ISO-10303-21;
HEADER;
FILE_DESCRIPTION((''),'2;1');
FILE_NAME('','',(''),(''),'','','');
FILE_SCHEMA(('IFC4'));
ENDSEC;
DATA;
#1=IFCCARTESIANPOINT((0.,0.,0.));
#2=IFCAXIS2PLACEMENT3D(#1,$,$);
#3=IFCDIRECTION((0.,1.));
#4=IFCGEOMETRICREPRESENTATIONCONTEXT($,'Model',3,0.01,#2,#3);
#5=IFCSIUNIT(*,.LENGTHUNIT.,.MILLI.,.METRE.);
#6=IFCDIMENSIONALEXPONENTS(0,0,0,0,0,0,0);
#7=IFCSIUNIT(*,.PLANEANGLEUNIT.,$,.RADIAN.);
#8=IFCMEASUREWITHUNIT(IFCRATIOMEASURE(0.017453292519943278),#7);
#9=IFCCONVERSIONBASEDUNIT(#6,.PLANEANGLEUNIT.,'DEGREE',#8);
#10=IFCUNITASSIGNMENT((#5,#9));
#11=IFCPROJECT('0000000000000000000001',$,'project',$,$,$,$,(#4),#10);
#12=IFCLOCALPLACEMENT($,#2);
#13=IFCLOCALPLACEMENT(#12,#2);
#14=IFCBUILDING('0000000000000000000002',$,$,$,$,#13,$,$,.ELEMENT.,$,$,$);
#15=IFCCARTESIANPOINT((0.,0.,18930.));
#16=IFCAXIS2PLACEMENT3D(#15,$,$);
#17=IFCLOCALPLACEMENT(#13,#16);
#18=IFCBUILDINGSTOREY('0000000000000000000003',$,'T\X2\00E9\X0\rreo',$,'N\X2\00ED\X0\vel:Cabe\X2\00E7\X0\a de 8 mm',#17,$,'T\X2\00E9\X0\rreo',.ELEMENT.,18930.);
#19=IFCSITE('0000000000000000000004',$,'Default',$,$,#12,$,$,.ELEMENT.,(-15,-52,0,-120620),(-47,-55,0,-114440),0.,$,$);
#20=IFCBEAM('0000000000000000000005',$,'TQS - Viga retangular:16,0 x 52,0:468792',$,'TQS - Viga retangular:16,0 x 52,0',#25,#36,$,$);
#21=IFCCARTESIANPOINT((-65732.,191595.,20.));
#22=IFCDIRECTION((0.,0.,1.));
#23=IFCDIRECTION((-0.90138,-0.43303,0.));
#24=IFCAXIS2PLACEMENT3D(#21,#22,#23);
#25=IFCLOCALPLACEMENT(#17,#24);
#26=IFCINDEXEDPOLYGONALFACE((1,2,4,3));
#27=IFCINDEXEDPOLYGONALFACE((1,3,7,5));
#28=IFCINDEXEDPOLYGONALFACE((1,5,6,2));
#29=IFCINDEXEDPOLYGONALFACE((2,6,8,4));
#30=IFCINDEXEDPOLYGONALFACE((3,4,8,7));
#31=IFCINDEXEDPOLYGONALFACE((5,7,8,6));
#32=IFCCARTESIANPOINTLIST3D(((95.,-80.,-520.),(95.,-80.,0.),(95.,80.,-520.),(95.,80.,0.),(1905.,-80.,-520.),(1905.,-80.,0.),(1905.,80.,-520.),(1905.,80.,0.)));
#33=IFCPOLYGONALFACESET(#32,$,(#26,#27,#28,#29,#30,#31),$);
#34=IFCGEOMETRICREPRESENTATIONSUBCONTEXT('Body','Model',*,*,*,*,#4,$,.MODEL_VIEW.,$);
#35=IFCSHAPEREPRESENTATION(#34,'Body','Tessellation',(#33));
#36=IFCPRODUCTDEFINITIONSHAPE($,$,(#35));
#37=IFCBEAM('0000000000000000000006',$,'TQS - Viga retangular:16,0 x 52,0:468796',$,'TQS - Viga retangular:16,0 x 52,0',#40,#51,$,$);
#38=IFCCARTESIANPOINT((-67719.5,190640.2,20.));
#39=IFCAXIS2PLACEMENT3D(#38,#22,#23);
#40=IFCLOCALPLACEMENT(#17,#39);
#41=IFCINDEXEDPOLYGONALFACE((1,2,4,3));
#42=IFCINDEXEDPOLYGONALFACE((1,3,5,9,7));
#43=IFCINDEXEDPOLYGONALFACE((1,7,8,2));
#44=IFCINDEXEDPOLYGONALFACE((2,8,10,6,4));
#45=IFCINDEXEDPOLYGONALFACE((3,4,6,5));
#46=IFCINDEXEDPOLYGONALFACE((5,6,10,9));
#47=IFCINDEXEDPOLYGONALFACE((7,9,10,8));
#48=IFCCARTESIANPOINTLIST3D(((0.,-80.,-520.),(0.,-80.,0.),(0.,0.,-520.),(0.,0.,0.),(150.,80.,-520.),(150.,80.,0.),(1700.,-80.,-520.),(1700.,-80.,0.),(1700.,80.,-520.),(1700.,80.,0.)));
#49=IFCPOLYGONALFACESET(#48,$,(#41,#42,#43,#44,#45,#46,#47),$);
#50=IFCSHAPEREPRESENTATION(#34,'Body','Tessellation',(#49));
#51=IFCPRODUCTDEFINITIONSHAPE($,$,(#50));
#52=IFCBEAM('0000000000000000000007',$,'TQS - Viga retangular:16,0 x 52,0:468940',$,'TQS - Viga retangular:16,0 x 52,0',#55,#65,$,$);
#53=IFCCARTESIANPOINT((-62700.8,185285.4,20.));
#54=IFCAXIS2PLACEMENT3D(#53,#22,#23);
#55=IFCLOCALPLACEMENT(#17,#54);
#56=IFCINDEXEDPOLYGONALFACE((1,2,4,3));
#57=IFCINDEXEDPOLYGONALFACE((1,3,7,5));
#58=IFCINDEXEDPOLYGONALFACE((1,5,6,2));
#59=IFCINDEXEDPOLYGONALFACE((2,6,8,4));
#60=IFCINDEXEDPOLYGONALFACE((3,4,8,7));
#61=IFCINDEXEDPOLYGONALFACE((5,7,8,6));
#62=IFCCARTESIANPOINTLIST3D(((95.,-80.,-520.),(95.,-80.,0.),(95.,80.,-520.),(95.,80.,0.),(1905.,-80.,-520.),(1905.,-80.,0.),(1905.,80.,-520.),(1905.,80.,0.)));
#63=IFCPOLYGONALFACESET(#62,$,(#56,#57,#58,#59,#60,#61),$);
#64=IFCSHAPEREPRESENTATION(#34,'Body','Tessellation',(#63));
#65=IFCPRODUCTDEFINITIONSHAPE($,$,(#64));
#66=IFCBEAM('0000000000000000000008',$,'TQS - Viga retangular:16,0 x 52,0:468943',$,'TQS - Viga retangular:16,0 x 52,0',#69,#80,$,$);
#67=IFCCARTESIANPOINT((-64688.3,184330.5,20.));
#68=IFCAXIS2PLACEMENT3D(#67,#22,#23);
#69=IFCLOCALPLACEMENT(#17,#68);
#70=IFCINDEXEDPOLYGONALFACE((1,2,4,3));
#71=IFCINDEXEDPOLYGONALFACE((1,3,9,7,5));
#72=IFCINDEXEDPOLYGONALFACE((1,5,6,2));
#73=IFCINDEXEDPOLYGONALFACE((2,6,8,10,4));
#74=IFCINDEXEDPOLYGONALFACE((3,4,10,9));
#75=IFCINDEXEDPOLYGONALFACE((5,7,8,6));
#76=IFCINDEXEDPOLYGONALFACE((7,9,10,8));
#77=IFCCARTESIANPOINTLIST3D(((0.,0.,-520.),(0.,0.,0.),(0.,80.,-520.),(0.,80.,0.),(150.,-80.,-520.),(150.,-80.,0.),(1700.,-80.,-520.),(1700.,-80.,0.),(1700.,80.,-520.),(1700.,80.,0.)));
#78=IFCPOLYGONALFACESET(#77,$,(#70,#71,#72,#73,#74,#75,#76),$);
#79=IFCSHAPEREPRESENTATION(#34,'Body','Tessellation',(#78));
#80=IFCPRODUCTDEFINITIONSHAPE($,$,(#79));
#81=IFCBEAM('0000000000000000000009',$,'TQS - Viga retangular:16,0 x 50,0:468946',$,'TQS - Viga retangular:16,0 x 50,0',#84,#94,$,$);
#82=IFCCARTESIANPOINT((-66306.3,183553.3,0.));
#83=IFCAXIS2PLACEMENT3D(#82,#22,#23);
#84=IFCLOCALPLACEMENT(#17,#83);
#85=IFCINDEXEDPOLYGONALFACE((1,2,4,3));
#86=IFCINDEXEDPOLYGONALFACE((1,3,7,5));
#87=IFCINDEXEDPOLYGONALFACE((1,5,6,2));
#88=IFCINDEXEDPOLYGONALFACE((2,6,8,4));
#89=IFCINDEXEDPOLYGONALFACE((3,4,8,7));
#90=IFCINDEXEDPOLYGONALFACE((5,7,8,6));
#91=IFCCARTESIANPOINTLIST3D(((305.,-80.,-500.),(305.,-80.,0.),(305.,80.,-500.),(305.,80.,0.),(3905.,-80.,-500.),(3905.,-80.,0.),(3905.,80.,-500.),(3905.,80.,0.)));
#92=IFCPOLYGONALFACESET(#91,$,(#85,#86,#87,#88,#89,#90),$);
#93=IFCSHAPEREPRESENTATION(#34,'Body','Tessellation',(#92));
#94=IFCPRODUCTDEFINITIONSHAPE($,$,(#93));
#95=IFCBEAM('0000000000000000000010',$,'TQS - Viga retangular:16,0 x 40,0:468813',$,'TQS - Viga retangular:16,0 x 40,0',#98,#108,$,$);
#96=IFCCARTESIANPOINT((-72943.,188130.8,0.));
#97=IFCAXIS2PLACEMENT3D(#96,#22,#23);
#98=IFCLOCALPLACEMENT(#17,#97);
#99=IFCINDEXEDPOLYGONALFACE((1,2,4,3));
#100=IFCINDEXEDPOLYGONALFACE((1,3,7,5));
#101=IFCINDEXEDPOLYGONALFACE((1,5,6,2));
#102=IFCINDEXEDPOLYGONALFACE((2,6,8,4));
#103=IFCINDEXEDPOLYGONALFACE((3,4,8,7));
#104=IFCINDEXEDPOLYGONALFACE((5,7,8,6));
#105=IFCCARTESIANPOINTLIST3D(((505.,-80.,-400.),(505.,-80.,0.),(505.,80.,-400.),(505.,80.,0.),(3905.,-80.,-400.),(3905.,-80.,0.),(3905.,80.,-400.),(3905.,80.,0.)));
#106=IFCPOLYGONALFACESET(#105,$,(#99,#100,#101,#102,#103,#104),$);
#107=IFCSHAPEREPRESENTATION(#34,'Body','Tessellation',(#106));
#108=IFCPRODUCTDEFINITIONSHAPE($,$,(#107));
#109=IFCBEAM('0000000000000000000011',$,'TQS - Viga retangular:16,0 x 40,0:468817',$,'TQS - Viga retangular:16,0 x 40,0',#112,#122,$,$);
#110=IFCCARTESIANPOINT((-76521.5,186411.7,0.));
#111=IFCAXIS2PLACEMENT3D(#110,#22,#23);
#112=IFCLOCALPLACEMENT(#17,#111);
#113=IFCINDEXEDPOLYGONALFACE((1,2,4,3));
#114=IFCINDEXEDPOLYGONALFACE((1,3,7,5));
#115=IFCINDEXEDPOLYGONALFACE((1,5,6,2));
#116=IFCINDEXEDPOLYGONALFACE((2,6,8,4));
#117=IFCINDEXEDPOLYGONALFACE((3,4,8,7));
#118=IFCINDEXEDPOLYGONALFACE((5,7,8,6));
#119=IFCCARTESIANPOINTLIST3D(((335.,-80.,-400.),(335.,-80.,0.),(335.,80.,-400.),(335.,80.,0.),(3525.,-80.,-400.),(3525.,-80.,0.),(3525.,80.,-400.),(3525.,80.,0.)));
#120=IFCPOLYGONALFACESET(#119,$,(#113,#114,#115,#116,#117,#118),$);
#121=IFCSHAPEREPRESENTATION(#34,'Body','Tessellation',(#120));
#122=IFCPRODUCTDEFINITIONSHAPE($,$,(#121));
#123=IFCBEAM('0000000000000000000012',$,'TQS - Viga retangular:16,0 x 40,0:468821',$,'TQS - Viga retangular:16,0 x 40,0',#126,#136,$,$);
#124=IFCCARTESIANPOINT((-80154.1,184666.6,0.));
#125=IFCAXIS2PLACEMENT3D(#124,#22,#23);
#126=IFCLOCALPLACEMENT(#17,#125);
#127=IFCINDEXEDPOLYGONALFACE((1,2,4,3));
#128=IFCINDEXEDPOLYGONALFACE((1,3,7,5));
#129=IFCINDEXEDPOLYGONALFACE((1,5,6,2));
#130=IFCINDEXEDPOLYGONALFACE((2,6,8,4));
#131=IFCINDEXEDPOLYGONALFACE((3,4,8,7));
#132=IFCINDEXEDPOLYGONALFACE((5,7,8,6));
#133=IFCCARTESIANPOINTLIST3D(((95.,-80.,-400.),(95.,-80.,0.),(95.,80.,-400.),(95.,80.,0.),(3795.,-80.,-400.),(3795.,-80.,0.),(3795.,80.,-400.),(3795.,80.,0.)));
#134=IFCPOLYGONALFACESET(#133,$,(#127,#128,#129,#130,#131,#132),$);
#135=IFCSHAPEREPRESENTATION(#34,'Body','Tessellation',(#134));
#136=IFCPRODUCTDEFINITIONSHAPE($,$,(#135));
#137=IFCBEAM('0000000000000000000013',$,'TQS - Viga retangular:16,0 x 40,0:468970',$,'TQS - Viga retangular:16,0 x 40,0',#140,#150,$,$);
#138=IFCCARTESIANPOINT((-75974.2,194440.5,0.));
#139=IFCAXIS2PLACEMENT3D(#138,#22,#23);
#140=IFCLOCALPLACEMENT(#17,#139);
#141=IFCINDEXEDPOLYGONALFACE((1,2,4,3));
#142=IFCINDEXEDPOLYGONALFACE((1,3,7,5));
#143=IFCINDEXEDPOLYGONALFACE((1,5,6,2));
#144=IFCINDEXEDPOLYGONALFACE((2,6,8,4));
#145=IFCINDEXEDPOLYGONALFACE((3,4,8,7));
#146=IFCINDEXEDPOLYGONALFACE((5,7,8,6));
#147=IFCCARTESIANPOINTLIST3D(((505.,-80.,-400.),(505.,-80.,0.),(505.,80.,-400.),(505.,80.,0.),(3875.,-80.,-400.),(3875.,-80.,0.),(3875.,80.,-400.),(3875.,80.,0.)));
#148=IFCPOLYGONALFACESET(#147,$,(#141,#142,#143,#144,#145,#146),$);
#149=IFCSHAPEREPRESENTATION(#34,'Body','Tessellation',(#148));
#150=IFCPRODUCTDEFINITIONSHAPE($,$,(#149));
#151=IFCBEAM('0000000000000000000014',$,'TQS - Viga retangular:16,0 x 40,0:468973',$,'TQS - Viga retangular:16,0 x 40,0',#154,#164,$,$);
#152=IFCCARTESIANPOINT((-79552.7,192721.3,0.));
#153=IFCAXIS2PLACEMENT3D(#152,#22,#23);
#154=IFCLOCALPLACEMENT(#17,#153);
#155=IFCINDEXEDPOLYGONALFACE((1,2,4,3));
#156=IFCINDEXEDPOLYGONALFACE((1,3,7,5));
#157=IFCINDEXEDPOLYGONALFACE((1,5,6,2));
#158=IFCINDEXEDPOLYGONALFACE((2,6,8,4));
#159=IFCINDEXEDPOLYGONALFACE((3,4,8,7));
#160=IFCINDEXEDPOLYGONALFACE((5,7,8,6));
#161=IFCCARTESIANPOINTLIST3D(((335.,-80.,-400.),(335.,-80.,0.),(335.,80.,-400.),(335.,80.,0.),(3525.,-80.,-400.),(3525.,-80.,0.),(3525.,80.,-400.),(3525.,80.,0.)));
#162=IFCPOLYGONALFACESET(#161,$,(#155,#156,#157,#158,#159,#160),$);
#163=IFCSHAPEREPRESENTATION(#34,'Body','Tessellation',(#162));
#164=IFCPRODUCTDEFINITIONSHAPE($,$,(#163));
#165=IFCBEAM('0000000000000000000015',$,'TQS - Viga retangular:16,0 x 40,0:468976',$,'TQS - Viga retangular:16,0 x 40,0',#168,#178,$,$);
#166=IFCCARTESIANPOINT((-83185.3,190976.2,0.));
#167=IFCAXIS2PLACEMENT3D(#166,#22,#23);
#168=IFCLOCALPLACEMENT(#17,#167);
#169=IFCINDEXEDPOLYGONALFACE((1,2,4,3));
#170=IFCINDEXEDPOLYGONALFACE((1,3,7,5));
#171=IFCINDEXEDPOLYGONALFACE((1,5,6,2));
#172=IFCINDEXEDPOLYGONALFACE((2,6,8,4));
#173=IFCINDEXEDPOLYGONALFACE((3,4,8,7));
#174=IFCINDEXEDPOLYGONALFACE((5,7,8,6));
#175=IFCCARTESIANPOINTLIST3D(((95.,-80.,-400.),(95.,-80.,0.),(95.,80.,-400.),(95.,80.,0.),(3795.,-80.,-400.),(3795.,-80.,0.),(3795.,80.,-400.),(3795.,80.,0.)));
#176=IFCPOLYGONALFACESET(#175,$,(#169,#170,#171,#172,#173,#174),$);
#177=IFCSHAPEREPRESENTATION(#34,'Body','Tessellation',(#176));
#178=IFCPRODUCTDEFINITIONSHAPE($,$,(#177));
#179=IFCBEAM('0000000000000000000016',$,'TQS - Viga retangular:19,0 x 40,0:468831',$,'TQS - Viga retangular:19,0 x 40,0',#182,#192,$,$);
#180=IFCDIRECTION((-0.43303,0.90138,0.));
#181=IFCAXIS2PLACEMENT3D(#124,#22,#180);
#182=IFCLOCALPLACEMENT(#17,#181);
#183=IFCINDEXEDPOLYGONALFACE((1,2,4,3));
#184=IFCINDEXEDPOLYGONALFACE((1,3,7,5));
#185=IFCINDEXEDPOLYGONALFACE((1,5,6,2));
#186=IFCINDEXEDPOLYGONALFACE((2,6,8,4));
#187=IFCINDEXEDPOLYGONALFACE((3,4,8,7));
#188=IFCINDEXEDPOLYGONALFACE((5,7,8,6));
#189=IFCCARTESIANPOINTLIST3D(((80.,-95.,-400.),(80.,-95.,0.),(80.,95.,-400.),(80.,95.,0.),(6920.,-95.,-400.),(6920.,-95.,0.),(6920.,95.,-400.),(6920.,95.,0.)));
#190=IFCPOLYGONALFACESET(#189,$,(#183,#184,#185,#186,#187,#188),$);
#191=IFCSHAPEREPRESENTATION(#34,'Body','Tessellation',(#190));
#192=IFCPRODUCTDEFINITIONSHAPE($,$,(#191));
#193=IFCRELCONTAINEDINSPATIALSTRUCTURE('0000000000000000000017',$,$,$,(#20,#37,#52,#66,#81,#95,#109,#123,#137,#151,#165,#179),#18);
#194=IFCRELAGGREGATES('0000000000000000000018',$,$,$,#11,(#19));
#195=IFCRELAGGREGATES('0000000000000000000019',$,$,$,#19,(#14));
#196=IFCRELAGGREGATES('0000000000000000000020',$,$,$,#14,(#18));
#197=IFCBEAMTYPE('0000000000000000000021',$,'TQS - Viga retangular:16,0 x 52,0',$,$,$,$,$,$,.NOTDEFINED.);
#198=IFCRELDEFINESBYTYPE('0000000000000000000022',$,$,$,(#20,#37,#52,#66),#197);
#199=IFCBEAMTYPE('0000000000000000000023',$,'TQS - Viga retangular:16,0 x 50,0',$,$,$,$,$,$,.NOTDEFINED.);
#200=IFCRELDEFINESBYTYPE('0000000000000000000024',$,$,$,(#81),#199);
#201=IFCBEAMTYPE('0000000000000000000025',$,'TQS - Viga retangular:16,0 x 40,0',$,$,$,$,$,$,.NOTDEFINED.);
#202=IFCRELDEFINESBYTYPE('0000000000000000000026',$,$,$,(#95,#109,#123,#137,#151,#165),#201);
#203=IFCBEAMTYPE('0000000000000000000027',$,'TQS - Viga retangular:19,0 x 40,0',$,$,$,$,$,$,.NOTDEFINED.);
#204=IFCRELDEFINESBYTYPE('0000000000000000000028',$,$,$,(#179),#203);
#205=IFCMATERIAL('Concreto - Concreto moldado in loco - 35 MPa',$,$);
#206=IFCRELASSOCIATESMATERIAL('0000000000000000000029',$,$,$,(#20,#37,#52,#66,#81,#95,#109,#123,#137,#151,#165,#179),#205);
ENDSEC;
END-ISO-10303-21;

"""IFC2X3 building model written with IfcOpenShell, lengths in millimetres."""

from ifc_helpers import new_model, entity, si_unit, converted_unit, direction, frame, frame_2d, origin, origin_2d_with_axis, place, context, subcontext, project, spatial, rectangle, extrude, clip, halfspace, material, type_object, element, save


model = new_model("IFC2X3")

# Units and contexts
model_context = context("Model", 3, precision=0.01, world=origin(), true_north=direction((0.0, 1.0)))
body_context = subcontext(model_context, "Body", "Model", "MODEL_VIEW")
ifc_project = project(units=[si_unit("LENGTHUNIT", "METRE", prefix="MILLI"), converted_unit("PLANEANGLEUNIT", "DEGREE", entity("IfcRatioMeasure", 0.017453292519943278), si_unit("PLANEANGLEUNIT", "RADIAN"), dimensions=[0, 0, 0, 0, 0, 0, 0])], contexts=[model_context])

# Site, building, storey
site_placement = place(None, origin())
site = spatial("IfcSite", under=ifc_project, at=site_placement, Name="Default", CompositionType="ELEMENT", RefLatitude=(-15, -52, 0, -120620), RefLongitude=(-47, -55, 0, -114440), RefElevation=0.0)
building_placement = place(site_placement, origin())
building = spatial("IfcBuilding", under=site, at=building_placement, CompositionType="ELEMENT")
storey_placement = place(building_placement, frame((0.0, 0.0, 18930.0)))
storey = spatial("IfcBuildingStorey", under=building, at=storey_placement, Name="Térreo", ObjectType="Nível:Cabeça de 8 mm", LongName="Térreo", CompositionType="ELEMENT", Elevation=18930.0)

# Beams
ifc_material_1 = material(Name="Concreto - Concreto moldado in loco - 35 MPa")
beam_type_1 = type_object("IfcBeamType", Name="TQS - Viga retangular:16,0 x 52,0", PredefinedType="NOTDEFINED")
beam_1_placement = place(storey_placement, frame((-65732.0, 191595.0, 20.0), z_axis=(0.0, 0.0, 1.0), x_axis=(-0.90138, -0.43303, 0.0)))
element("IfcBeam", 1, at=beam_1_placement, inside=storey, type_object=beam_type_1, material=ifc_material_1, Name="TQS - Viga retangular:16,0 x 52,0:468792", ObjectType="TQS - Viga retangular:16,0 x 52,0", context=body_context, shape_type="SweptSolid", body=[
    extrude(rectangle(XDim=520.0, YDim=160.0, at=frame_2d((0.0, 0.0), x_axis=(1.0, 0.0))), frame((95.0, 0.0, -260.0), z_axis=(1.0, 0.0, 0.0), x_axis=(0.0, 0.0, -1.0)), (0.0, 0.0, 1.0), 1810.0),
])
beam_2_placement = place(storey_placement, frame((-67719.5, 190640.2, 20.0), z_axis=(0.0, 0.0, 1.0), x_axis=(-0.90138, -0.43303, 0.0)))
element("IfcBeam", 2, at=beam_2_placement, inside=storey, type_object=beam_type_1, material=ifc_material_1, Name="TQS - Viga retangular:16,0 x 52,0:468796", ObjectType="TQS - Viga retangular:16,0 x 52,0", context=body_context, shape_type="SweptSolid", body=[
    clip(extrude(rectangle(XDim=520.0, YDim=160.0, at=frame_2d((0.0, 0.0), x_axis=(1.0, 0.0))), frame((0.0, 0.0, -260.0), z_axis=(1.0, 0.0, 0.0), x_axis=(0.0, 0.0, -1.0)), (0.0, 0.0, 1.0), 1700.0), halfspace(frame((150.0, 80.0, 0.0), z_axis=(-0.470588, 0.882353, 0.0), x_axis=(-0.882353, -0.470588, 0.0)), False)),
])
beam_3_placement = place(storey_placement, frame((-62700.8, 185285.4, 20.0), z_axis=(0.0, 0.0, 1.0), x_axis=(-0.90138, -0.43303, 0.0)))
element("IfcBeam", 3, at=beam_3_placement, inside=storey, type_object=beam_type_1, material=ifc_material_1, Name="TQS - Viga retangular:16,0 x 52,0:468940", ObjectType="TQS - Viga retangular:16,0 x 52,0", context=body_context, shape_type="SweptSolid", body=[
    extrude(rectangle(XDim=520.0, YDim=160.0, at=frame_2d((0.0, 0.0), x_axis=(1.0, 0.0))), frame((95.0, 0.0, -260.0), z_axis=(1.0, 0.0, 0.0), x_axis=(0.0, 0.0, -1.0)), (0.0, 0.0, 1.0), 1810.0),
])
beam_4_placement = place(storey_placement, frame((-64688.3, 184330.5, 20.0), z_axis=(0.0, 0.0, 1.0), x_axis=(-0.90138, -0.43303, 0.0)))
element("IfcBeam", 4, at=beam_4_placement, inside=storey, type_object=beam_type_1, material=ifc_material_1, Name="TQS - Viga retangular:16,0 x 52,0:468943", ObjectType="TQS - Viga retangular:16,0 x 52,0", context=body_context, shape_type="SweptSolid", body=[
    clip(extrude(rectangle(XDim=520.0, YDim=160.0, at=frame_2d((0.0, 0.0), x_axis=(1.0, 0.0))), frame((0.0, 0.0, -260.0), z_axis=(1.0, 0.0, 0.0), x_axis=(0.0, 0.0, -1.0)), (0.0, 0.0, 1.0), 1700.0), halfspace(frame((150.0, -80.0, 0.0), z_axis=(-0.470588, -0.882353, 0.0), x_axis=(-0.882353, 0.470588, 0.0)), False)),
])
beam_type_2 = type_object("IfcBeamType", Name="TQS - Viga retangular:16,0 x 50,0", PredefinedType="NOTDEFINED")
beam_5_placement = place(storey_placement, frame((-66306.3, 183553.3, 0.0), z_axis=(0.0, 0.0, 1.0), x_axis=(-0.90138, -0.43303, 0.0)))
element("IfcBeam", 5, at=beam_5_placement, inside=storey, type_object=beam_type_2, material=ifc_material_1, Name="TQS - Viga retangular:16,0 x 50,0:468946", ObjectType="TQS - Viga retangular:16,0 x 50,0", context=body_context, shape_type="SweptSolid", body=[
    extrude(rectangle(XDim=500.0, YDim=160.0, at=frame_2d((0.0, 0.0), x_axis=(1.0, 0.0))), frame((305.0, 0.0, -250.0), z_axis=(1.0, 0.0, 0.0), x_axis=(0.0, 0.0, -1.0)), (0.0, 0.0, 1.0), 3600.0),
])
beam_type_3 = type_object("IfcBeamType", Name="TQS - Viga retangular:16,0 x 40,0", PredefinedType="NOTDEFINED")
beam_6_placement = place(storey_placement, frame((-72943.0, 188130.8, 0.0), z_axis=(0.0, 0.0, 1.0), x_axis=(-0.90138, -0.43303, 0.0)))
element("IfcBeam", 6, at=beam_6_placement, inside=storey, type_object=beam_type_3, material=ifc_material_1, Name="TQS - Viga retangular:16,0 x 40,0:468813", ObjectType="TQS - Viga retangular:16,0 x 40,0", context=body_context, shape_type="SweptSolid", body=[
    extrude(rectangle(XDim=400.0, YDim=160.0, at=frame_2d((0.0, 0.0), x_axis=(1.0, 0.0))), frame((505.0, 0.0, -200.0), z_axis=(1.0, 0.0, 0.0), x_axis=(0.0, 0.0, -1.0)), (0.0, 0.0, 1.0), 3400.0),
])
beam_7_placement = place(storey_placement, frame((-76521.5, 186411.7, 0.0), z_axis=(0.0, 0.0, 1.0), x_axis=(-0.90138, -0.43303, 0.0)))
element("IfcBeam", 7, at=beam_7_placement, inside=storey, type_object=beam_type_3, material=ifc_material_1, Name="TQS - Viga retangular:16,0 x 40,0:468817", ObjectType="TQS - Viga retangular:16,0 x 40,0", context=body_context, shape_type="SweptSolid", body=[
    extrude(rectangle(XDim=400.0, YDim=160.0, at=frame_2d((0.0, 0.0), x_axis=(1.0, 0.0))), frame((335.0, 0.0, -200.0), z_axis=(1.0, 0.0, 0.0), x_axis=(0.0, 0.0, -1.0)), (0.0, 0.0, 1.0), 3190.0),
])
beam_8_placement = place(storey_placement, frame((-80154.1, 184666.6, 0.0), z_axis=(0.0, 0.0, 1.0), x_axis=(-0.90138, -0.43303, 0.0)))
element("IfcBeam", 8, at=beam_8_placement, inside=storey, type_object=beam_type_3, material=ifc_material_1, Name="TQS - Viga retangular:16,0 x 40,0:468821", ObjectType="TQS - Viga retangular:16,0 x 40,0", context=body_context, shape_type="SweptSolid", body=[
    extrude(rectangle(XDim=400.0, YDim=160.0, at=frame_2d((0.0, 0.0), x_axis=(1.0, 0.0))), frame((95.0, 0.0, -200.0), z_axis=(1.0, 0.0, 0.0), x_axis=(0.0, 0.0, -1.0)), (0.0, 0.0, 1.0), 3700.0),
])
beam_9_placement = place(storey_placement, frame((-75974.2, 194440.5, 0.0), z_axis=(0.0, 0.0, 1.0), x_axis=(-0.90138, -0.43303, 0.0)))
element("IfcBeam", 9, at=beam_9_placement, inside=storey, type_object=beam_type_3, material=ifc_material_1, Name="TQS - Viga retangular:16,0 x 40,0:468970", ObjectType="TQS - Viga retangular:16,0 x 40,0", context=body_context, shape_type="SweptSolid", body=[
    extrude(rectangle(XDim=400.0, YDim=160.0, at=frame_2d((0.0, 0.0), x_axis=(1.0, 0.0))), frame((505.0, 0.0, -200.0), z_axis=(1.0, 0.0, 0.0), x_axis=(0.0, 0.0, -1.0)), (0.0, 0.0, 1.0), 3370.0),
])
beam_10_placement = place(storey_placement, frame((-79552.7, 192721.3, 0.0), z_axis=(0.0, 0.0, 1.0), x_axis=(-0.90138, -0.43303, 0.0)))
element("IfcBeam", 10, at=beam_10_placement, inside=storey, type_object=beam_type_3, material=ifc_material_1, Name="TQS - Viga retangular:16,0 x 40,0:468973", ObjectType="TQS - Viga retangular:16,0 x 40,0", context=body_context, shape_type="SweptSolid", body=[
    extrude(rectangle(XDim=400.0, YDim=160.0, at=frame_2d((0.0, 0.0), x_axis=(1.0, 0.0))), frame((335.0, 0.0, -200.0), z_axis=(1.0, 0.0, 0.0), x_axis=(0.0, 0.0, -1.0)), (0.0, 0.0, 1.0), 3190.0),
])
beam_11_placement = place(storey_placement, frame((-83185.3, 190976.2, 0.0), z_axis=(0.0, 0.0, 1.0), x_axis=(-0.90138, -0.43303, 0.0)))
element("IfcBeam", 11, at=beam_11_placement, inside=storey, type_object=beam_type_3, material=ifc_material_1, Name="TQS - Viga retangular:16,0 x 40,0:468976", ObjectType="TQS - Viga retangular:16,0 x 40,0", context=body_context, shape_type="SweptSolid", body=[
    extrude(rectangle(XDim=400.0, YDim=160.0, at=frame_2d((0.0, 0.0), x_axis=(1.0, 0.0))), frame((95.0, 0.0, -200.0), z_axis=(1.0, 0.0, 0.0), x_axis=(0.0, 0.0, -1.0)), (0.0, 0.0, 1.0), 3700.0),
])
beam_type_4 = type_object("IfcBeamType", Name="TQS - Viga retangular:19,0 x 40,0", PredefinedType="NOTDEFINED")
beam_12_placement = place(storey_placement, frame((-80154.1, 184666.6, 0.0), z_axis=(0.0, 0.0, 1.0), x_axis=(-0.43303, 0.90138, 0.0)))
element("IfcBeam", 12, at=beam_12_placement, inside=storey, type_object=beam_type_4, material=ifc_material_1, Name="TQS - Viga retangular:19,0 x 40,0:468831", ObjectType="TQS - Viga retangular:19,0 x 40,0", context=body_context, shape_type="SweptSolid", body=[
    extrude(rectangle(XDim=400.0, YDim=190.0, at=origin_2d_with_axis()), frame((80.0, 0.0, -200.0), z_axis=(1.0, 0.0, 0.0), x_axis=(0.0, 0.0, -1.0)), (0.0, 0.0, 1.0), 6840.0),
])

save(model, "model.ifc")
